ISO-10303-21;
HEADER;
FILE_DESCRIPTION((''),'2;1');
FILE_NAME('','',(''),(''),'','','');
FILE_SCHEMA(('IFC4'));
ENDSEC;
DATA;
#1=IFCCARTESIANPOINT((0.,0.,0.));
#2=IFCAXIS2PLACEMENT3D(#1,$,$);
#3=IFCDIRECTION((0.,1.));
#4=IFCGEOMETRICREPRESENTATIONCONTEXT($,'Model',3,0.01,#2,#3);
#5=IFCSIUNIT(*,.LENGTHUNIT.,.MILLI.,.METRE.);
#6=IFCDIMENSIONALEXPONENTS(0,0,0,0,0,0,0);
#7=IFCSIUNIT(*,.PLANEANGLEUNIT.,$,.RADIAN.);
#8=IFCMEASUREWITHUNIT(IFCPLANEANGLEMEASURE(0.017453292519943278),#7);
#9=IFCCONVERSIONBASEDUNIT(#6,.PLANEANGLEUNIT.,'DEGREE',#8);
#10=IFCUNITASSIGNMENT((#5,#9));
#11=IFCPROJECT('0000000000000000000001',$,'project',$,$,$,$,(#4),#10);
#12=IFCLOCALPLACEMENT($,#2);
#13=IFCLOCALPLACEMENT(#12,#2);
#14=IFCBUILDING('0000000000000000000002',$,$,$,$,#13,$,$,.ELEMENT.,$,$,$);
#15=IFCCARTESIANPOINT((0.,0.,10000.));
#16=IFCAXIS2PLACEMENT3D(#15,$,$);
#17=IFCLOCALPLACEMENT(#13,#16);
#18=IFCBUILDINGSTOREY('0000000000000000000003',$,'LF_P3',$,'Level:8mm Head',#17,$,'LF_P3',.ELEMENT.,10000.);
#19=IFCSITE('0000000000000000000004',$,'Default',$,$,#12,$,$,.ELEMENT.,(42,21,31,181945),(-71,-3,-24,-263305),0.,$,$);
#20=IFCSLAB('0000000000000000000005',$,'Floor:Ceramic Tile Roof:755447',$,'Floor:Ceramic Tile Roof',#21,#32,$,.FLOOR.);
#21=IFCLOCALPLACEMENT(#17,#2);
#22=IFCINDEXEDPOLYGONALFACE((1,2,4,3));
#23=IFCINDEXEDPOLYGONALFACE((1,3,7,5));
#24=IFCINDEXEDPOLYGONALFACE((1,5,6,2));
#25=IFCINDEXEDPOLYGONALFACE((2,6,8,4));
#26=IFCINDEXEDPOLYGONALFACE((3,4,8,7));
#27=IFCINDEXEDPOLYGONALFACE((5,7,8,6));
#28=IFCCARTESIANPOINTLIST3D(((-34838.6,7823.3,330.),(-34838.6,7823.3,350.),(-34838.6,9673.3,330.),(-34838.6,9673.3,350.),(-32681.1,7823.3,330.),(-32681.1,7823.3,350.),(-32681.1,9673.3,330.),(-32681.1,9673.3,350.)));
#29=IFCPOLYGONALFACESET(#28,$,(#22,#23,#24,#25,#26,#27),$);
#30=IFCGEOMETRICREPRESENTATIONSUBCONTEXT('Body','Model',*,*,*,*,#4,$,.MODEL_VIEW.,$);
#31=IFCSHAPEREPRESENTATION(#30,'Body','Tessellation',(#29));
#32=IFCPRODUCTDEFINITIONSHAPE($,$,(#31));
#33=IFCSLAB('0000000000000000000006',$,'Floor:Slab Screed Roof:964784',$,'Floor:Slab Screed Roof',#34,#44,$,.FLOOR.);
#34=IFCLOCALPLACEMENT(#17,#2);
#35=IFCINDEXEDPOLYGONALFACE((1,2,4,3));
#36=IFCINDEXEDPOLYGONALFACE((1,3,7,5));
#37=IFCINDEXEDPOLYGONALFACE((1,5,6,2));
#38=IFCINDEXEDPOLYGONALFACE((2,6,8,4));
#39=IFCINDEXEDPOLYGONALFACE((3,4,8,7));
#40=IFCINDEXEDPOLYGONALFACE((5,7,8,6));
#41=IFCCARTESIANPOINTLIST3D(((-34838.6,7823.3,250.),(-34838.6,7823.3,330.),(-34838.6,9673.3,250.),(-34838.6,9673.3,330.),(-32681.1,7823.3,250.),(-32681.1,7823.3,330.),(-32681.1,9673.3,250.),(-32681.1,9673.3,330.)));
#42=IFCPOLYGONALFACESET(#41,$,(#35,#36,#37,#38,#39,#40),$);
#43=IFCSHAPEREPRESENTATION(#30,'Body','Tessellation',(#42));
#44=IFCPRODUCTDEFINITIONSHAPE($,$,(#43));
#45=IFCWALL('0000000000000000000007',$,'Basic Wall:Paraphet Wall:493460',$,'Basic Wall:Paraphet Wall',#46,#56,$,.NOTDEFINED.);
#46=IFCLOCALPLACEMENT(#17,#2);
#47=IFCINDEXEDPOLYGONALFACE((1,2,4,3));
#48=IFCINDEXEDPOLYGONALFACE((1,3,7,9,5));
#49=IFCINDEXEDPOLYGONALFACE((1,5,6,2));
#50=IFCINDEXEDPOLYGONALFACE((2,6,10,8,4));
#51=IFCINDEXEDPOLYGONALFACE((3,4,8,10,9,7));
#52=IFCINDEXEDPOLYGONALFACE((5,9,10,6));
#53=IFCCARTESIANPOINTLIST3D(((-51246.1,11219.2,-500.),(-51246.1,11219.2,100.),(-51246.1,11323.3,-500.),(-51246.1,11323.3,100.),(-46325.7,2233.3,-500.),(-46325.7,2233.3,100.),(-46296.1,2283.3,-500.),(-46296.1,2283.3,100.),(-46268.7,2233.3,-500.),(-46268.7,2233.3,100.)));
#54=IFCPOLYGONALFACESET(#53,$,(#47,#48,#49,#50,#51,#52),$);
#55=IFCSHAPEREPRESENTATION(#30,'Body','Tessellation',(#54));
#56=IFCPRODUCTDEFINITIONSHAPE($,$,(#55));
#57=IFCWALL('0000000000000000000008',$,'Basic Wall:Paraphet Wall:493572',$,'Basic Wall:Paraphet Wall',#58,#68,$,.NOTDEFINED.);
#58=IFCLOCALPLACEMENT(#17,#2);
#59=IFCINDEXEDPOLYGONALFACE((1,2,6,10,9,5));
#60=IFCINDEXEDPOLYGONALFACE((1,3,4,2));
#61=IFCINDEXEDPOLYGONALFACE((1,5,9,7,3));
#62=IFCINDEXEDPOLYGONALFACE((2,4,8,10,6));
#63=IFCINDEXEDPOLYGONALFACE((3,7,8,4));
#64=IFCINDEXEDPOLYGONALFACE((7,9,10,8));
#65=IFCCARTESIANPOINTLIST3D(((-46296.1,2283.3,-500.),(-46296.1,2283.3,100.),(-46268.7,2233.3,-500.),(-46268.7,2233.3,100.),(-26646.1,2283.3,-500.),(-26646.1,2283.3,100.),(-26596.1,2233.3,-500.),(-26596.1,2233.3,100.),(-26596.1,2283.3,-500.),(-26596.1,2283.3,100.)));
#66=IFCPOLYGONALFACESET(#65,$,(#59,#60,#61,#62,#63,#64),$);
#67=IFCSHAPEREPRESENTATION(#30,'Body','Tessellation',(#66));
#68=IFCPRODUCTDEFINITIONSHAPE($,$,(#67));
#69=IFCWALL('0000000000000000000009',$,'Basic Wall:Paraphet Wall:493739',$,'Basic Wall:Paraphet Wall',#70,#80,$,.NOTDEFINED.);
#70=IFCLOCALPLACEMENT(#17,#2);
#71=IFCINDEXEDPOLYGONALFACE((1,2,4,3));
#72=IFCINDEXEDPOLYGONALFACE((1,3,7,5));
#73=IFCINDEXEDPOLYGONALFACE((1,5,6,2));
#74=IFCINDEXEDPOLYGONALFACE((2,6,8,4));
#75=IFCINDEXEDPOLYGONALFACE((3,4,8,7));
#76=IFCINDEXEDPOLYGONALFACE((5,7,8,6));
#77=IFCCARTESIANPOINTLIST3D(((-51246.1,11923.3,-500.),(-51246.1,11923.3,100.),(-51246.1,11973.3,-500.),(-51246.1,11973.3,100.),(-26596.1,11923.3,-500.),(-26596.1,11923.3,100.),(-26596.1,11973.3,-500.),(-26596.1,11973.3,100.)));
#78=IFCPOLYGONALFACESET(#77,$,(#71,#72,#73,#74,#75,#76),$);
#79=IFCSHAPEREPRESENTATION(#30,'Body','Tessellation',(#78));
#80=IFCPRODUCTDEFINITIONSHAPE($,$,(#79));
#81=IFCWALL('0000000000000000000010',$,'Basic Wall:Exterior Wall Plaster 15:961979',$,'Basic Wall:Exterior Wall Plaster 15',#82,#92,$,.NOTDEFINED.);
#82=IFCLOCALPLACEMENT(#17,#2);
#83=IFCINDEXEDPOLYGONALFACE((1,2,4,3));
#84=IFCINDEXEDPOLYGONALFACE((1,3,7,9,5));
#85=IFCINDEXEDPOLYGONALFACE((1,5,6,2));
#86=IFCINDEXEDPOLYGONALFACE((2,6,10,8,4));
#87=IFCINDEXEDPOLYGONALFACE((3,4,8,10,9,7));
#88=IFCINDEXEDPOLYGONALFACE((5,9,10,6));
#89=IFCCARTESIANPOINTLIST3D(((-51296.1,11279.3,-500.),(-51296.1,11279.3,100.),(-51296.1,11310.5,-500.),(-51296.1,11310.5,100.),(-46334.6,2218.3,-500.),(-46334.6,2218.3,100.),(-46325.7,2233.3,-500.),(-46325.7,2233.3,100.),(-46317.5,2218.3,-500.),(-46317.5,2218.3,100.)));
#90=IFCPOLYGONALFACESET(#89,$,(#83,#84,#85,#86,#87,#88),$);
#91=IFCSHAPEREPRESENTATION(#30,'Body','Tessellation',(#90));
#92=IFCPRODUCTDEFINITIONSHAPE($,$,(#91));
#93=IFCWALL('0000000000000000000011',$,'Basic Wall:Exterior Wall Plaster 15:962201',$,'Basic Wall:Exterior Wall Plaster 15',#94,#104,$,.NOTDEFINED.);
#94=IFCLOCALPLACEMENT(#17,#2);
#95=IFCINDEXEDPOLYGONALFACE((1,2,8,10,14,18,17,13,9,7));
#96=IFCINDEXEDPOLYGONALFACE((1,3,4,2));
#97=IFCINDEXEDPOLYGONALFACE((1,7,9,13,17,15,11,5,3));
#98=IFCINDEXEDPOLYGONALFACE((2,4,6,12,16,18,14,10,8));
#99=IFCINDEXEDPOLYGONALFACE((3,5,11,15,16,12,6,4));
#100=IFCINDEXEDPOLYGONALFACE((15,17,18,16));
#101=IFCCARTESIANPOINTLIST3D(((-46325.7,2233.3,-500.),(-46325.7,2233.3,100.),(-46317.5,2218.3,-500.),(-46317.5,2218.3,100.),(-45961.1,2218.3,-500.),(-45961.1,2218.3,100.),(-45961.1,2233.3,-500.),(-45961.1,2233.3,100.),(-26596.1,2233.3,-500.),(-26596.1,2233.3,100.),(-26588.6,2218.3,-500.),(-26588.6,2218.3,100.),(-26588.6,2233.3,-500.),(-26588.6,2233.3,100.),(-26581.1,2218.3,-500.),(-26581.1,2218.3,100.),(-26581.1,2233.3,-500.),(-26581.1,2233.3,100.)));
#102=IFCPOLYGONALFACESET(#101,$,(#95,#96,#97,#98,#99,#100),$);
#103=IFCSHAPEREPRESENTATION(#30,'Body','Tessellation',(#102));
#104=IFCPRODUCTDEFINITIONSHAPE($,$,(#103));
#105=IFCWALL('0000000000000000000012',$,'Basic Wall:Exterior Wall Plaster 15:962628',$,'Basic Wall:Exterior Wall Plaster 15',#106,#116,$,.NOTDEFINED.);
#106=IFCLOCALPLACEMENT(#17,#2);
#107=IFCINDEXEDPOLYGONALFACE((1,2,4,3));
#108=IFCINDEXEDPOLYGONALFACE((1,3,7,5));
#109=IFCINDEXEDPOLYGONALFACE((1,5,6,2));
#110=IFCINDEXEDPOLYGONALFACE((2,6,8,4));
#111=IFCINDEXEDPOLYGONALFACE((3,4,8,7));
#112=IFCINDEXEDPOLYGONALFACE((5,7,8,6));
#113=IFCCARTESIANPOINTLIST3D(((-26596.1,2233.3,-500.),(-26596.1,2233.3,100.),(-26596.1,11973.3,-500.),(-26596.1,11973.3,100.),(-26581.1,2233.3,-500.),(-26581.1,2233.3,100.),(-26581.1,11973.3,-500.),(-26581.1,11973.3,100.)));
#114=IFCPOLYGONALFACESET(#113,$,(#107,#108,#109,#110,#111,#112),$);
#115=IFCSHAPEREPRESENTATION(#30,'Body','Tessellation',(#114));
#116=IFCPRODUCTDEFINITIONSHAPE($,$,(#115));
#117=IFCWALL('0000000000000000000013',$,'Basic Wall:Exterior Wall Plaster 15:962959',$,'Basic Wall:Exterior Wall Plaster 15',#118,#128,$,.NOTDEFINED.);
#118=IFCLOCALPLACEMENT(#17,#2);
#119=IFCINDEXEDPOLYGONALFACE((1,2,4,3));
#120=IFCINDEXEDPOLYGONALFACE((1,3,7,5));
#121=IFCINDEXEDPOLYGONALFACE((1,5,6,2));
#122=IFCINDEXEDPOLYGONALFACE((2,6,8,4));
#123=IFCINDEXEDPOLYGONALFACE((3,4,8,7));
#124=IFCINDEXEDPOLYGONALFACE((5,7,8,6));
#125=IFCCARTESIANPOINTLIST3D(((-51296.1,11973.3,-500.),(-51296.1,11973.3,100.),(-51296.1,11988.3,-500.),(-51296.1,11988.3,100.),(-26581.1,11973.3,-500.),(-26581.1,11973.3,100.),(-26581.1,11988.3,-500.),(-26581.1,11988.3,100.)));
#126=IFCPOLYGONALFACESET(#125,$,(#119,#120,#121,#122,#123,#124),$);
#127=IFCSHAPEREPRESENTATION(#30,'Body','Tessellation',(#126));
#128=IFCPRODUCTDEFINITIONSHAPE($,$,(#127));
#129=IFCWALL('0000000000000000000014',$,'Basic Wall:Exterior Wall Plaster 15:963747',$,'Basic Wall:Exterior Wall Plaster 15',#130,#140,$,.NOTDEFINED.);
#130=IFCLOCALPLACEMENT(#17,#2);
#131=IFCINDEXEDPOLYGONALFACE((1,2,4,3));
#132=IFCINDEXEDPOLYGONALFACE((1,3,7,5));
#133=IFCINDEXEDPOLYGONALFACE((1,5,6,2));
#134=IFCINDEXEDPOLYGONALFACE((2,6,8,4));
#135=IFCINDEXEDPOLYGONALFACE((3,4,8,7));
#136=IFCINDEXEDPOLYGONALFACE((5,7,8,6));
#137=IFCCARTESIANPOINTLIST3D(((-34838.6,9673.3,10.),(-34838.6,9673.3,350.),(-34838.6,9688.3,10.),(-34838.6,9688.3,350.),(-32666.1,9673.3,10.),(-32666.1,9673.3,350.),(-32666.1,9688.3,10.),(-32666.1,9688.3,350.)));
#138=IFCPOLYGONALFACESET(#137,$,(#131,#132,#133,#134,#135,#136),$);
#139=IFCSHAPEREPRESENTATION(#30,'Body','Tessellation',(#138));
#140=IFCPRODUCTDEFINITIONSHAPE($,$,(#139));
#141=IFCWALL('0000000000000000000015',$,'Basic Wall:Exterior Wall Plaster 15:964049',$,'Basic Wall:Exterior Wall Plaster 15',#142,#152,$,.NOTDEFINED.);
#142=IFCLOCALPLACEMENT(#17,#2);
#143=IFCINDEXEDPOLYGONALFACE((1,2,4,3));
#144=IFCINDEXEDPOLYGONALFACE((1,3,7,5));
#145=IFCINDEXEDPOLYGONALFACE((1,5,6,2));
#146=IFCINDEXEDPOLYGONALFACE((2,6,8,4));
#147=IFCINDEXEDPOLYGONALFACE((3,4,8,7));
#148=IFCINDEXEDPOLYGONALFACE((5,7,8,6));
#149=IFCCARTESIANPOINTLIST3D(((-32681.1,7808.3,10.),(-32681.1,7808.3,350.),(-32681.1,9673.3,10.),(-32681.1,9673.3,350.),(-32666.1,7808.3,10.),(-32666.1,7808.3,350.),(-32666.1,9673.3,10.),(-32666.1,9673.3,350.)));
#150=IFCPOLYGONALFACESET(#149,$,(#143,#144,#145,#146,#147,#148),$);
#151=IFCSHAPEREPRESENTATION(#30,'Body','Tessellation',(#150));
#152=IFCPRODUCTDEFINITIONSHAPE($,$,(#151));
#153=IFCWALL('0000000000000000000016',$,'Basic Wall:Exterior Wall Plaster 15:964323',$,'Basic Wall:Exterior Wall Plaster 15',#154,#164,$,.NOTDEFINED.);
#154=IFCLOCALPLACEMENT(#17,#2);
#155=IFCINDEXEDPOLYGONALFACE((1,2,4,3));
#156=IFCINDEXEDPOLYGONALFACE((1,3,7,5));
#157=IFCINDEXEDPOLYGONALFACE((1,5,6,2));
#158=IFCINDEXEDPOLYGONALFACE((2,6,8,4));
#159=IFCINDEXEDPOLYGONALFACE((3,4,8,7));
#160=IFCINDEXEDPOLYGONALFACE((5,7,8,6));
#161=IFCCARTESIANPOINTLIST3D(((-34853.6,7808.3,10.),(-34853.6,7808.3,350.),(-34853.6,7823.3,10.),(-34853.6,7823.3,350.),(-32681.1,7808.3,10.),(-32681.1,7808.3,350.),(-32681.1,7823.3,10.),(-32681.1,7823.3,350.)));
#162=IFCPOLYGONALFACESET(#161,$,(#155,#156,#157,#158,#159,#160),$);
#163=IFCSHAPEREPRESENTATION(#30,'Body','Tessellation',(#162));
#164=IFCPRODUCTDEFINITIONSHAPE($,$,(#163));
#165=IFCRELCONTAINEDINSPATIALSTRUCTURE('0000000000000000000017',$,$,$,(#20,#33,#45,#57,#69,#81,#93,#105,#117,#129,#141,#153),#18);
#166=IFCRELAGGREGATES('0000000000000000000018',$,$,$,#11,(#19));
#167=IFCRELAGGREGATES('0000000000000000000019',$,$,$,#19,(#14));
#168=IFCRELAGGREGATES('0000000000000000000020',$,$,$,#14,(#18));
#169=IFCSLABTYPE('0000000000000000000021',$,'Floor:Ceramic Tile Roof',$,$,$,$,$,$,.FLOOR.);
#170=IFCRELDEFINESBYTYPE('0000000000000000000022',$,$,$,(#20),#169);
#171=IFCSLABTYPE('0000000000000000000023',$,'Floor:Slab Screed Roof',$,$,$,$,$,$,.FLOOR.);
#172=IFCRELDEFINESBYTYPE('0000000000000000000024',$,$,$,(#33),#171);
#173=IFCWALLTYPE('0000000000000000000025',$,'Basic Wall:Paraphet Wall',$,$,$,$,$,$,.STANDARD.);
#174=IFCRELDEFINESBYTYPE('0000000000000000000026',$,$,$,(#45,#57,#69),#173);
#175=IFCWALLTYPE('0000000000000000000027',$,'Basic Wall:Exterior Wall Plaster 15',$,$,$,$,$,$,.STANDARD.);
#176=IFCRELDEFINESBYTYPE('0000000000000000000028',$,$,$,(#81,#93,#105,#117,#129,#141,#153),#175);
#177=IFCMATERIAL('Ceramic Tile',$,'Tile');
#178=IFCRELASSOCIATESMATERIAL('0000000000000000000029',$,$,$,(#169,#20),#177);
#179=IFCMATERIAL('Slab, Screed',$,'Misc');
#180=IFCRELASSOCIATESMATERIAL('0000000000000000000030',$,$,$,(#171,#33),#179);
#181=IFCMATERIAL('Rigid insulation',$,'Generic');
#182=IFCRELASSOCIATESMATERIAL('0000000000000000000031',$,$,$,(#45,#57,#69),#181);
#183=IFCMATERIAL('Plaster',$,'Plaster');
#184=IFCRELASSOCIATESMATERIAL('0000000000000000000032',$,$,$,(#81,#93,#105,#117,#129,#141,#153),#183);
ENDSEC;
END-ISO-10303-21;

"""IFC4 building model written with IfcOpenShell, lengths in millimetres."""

from ifc_helpers import new_model, entity, si_unit, converted_unit, direction, frame, origin, place, context, subcontext, project, spatial, indexed_curve, outline, extrude, material, type_object, element, save


model = new_model("IFC4")

# Units and contexts
model_context = context("Model", 3, precision=0.01, world=origin(), true_north=direction((0.0, 1.0)))
body_context = subcontext(model_context, "Body", "Model", "MODEL_VIEW")
ifc_project = project(units=[si_unit("LENGTHUNIT", "METRE", prefix="MILLI"), converted_unit("PLANEANGLEUNIT", "DEGREE", entity("IfcPlaneAngleMeasure", 0.017453292519943278), si_unit("PLANEANGLEUNIT", "RADIAN"), dimensions=[0, 0, 0, 0, 0, 0, 0])], contexts=[model_context])

# Site, building, storey
site_placement = place(None, origin())
site = spatial("IfcSite", under=ifc_project, at=site_placement, Name="Default", CompositionType="ELEMENT", RefLatitude=(42, 21, 31, 181945), RefLongitude=(-71, -3, -24, -263305), RefElevation=0.0)
building_placement = place(site_placement, origin())
building = spatial("IfcBuilding", under=site, at=building_placement, CompositionType="ELEMENT")
storey_placement = place(building_placement, frame((0.0, 0.0, 10000.0)))
storey = spatial("IfcBuildingStorey", under=building, at=storey_placement, Name="LF_P3", ObjectType="Level:8mm Head", LongName="LF_P3", CompositionType="ELEMENT", Elevation=10000.0)

# Slab
ifc_material_1 = material(Name="Ceramic Tile", Category="Tile")
slab_type_1 = type_object("IfcSlabType", Name="Floor:Ceramic Tile Roof", PredefinedType="FLOOR", material=ifc_material_1)
slab_1_placement = place(storey_placement, origin())
element("IfcSlab", 1, at=slab_1_placement, inside=storey, type_object=slab_type_1, material=ifc_material_1, Name="Floor:Ceramic Tile Roof:755447", ObjectType="Floor:Ceramic Tile Roof", PredefinedType="FLOOR", context=body_context, shape_type="SweptSolid", body=[
    extrude(outline(indexed_curve([(-925.0, -1078.8), (925.0, -1078.8), (925.0, 1078.8), (-925.0, 1078.8), (-925.0, -1078.8)], self_intersect=False)), frame((-33759.9, 8748.3, 350.0), z_axis=(0.0, 0.0, -1.0), x_axis=(0.0, 1.0, 0.0)), (0.0, 0.0, 1.0), 20.0),
])

# Shared definitions
ifc_material_2 = material(Name="Rigid insulation", Category="Generic")
ifc_material_3 = material(Name="Slab, Screed", Category="Misc")
slab_type_2 = type_object("IfcSlabType", Name="Floor:Slab Screed Roof", PredefinedType="FLOOR", material=ifc_material_3)

# Slab
slab_2_placement = place(storey_placement, origin())
element("IfcSlab", 2, at=slab_2_placement, inside=storey, type_object=slab_type_2, material=ifc_material_3, Name="Floor:Slab Screed Roof:964784", ObjectType="Floor:Slab Screed Roof", PredefinedType="FLOOR", context=body_context, shape_type="SweptSolid", body=[
    extrude(outline(indexed_curve([(-925.0, -1078.8), (925.0, -1078.8), (925.0, 1078.8), (-925.0, 1078.8), (-925.0, -1078.8)], self_intersect=False)), frame((-33759.9, 8748.3, 330.0), z_axis=(0.0, 0.0, -1.0), x_axis=(0.0, 1.0, 0.0)), (0.0, 0.0, 1.0), 80.0),
])

# Walls
wall_type_1 = type_object("IfcWallType", Name="Basic Wall:Paraphet Wall", PredefinedType="STANDARD")
wall_1_placement = place(storey_placement, frame((-51268.0, 11311.3, -500.0), z_axis=(0.0, 0.0, 1.0), x_axis=(0.480279, -0.877116, 0.0)))
element("IfcWall", 3, at=wall_1_placement, inside=storey, type_object=wall_type_1, material=ifc_material_2, Name="Basic Wall:Paraphet Wall:493460", ObjectType="Basic Wall:Paraphet Wall", PredefinedType="NOTDEFINED", context=body_context, shape_type="SweptSolid", body=[
    extrude(outline(indexed_curve([(10336.1, -25.0), (10363.5, 25.0), (10306.5, 25.0), (0.0, 25.0), (91.3, -25.0), (10336.1, -25.0)], self_intersect=False)), origin(), (0.0, 0.0, 1.0), 600.0),
])
wall_2_placement = place(storey_placement, frame((-46296.1, 2258.3, -500.0)))
element("IfcWall", 4, at=wall_2_placement, inside=storey, type_object=wall_type_1, material=ifc_material_2, Name="Basic Wall:Paraphet Wall:493572", ObjectType="Basic Wall:Paraphet Wall", PredefinedType="NOTDEFINED", context=body_context, shape_type="SweptSolid", body=[
    extrude(outline(indexed_curve([(19700.0, -25.0), (19700.0, 25.0), (19650.0, 25.0), (0.0, 25.0), (27.4, -25.0), (19700.0, -25.0)], self_intersect=False)), origin(), (0.0, 0.0, 1.0), 600.0),
])
wall_3_placement = place(storey_placement, frame((-26596.1, 11948.3, -500.0), z_axis=(0.0, 0.0, 1.0), x_axis=(-1.0, 0.0, 0.0)))
element("IfcWall", 5, at=wall_3_placement, inside=storey, type_object=wall_type_1, material=ifc_material_2, Name="Basic Wall:Paraphet Wall:493739", ObjectType="Basic Wall:Paraphet Wall", PredefinedType="NOTDEFINED", context=body_context, shape_type="SweptSolid", body=[
    extrude(outline(indexed_curve([(24650.0, 25.0), (0.0, 25.0), (0.0, -25.0), (24650.0, -25.0), (24650.0, 25.0)], self_intersect=False)), origin(), (0.0, 0.0, 1.0), 600.0),
])
ifc_material_4 = material(Name="Plaster", Category="Plaster")
wall_type_2 = type_object("IfcWallType", Name="Basic Wall:Exterior Wall Plaster 15", PredefinedType="STANDARD")
wall_4_placement = place(storey_placement, frame((-51302.7, 11306.9, -500.0), z_axis=(0.0, 0.0, 1.0), x_axis=(0.480279, -0.877116, 0.0)))
element("IfcWall", 6, at=wall_4_placement, inside=storey, type_object=wall_type_2, material=ifc_material_4, Name="Basic Wall:Exterior Wall Plaster 15:961979", ObjectType="Basic Wall:Exterior Wall Plaster 15", PredefinedType="NOTDEFINED", context=body_context, shape_type="SweptSolid", body=[
    extrude(outline(indexed_curve([(10357.8, -7.5), (10366.0, 7.5), (10348.9, 7.5), (0.0, 7.5), (27.4, -7.5), (10357.8, -7.5)], self_intersect=False)), origin(), (0.0, 0.0, 1.0), 600.0),
])
wall_5_placement = place(storey_placement, frame((-46325.7, 2225.8, -500.0)))
element("IfcWall", 7, at=wall_5_placement, inside=storey, type_object=wall_type_2, material=ifc_material_4, Name="Basic Wall:Exterior Wall Plaster 15:962201", ObjectType="Basic Wall:Exterior Wall Plaster 15", PredefinedType="NOTDEFINED", context=body_context, shape_type="SweptSolid", body=[
    extrude(outline(indexed_curve([(19744.6, -7.5), (19744.6, 7.5), (19737.1, 7.5), (19729.6, 7.5), (364.6, 7.5), (0.0, 7.5), (8.2, -7.5), (364.6, -7.5), (19737.1, -7.5), (19744.6, -7.5)], self_intersect=False)), origin(), (0.0, 0.0, 1.0), 600.0),
])
wall_6_placement = place(storey_placement, frame((-26588.6, 2233.3, -500.0), z_axis=(0.0, 0.0, 1.0), x_axis=(0.0, 1.0, 0.0)))
element("IfcWall", 8, at=wall_6_placement, inside=storey, type_object=wall_type_2, material=ifc_material_4, Name="Basic Wall:Exterior Wall Plaster 15:962628", ObjectType="Basic Wall:Exterior Wall Plaster 15", PredefinedType="NOTDEFINED", context=body_context, shape_type="SweptSolid", body=[
    extrude(outline(indexed_curve([(9740.0, 7.5), (0.0, 7.5), (0.0, -7.5), (9740.0, -7.5), (9740.0, 7.5)], self_intersect=False)), origin(), (0.0, 0.0, 1.0), 600.0),
])
wall_7_placement = place(storey_placement, frame((-26581.1, 11980.8, -500.0), z_axis=(0.0, 0.0, 1.0), x_axis=(-1.0, 0.0, 0.0)))
element("IfcWall", 9, at=wall_7_placement, inside=storey, type_object=wall_type_2, material=ifc_material_4, Name="Basic Wall:Exterior Wall Plaster 15:962959", ObjectType="Basic Wall:Exterior Wall Plaster 15", PredefinedType="NOTDEFINED", context=body_context, shape_type="SweptSolid", body=[
    extrude(outline(indexed_curve([(24715.0, 7.5), (0.0, 7.5), (0.0, -7.5), (24715.0, -7.5), (24715.0, 7.5)], self_intersect=False)), origin(), (0.0, 0.0, 1.0), 600.0),
])
wall_8_placement = place(storey_placement, frame((-32666.1, 9680.8, 10.0), z_axis=(0.0, 0.0, 1.0), x_axis=(-1.0, 0.0, 0.0)))
element("IfcWall", 10, at=wall_8_placement, inside=storey, type_object=wall_type_2, material=ifc_material_4, Name="Basic Wall:Exterior Wall Plaster 15:963747", ObjectType="Basic Wall:Exterior Wall Plaster 15", PredefinedType="NOTDEFINED", context=body_context, shape_type="SweptSolid", body=[
    extrude(outline(indexed_curve([(2172.5, 7.5), (0.0, 7.5), (0.0, -7.5), (2172.5, -7.5), (2172.5, 7.5)], self_intersect=False)), origin(), (0.0, 0.0, 1.0), 340.0),
])
wall_9_placement = place(storey_placement, frame((-32673.6, 9673.3, 10.0), z_axis=(0.0, 0.0, 1.0), x_axis=(0.0, -1.0, 0.0)))
element("IfcWall", 11, at=wall_9_placement, inside=storey, type_object=wall_type_2, material=ifc_material_4, Name="Basic Wall:Exterior Wall Plaster 15:964049", ObjectType="Basic Wall:Exterior Wall Plaster 15", PredefinedType="NOTDEFINED", context=body_context, shape_type="SweptSolid", body=[
    extrude(outline(indexed_curve([(1865.0, 7.5), (0.0, 7.5), (0.0, -7.5), (1865.0, -7.5), (1865.0, 7.5)], self_intersect=False)), origin(), (0.0, 0.0, 1.0), 340.0),
])
wall_10_placement = place(storey_placement, frame((-32681.1, 7815.8, 10.0), z_axis=(0.0, 0.0, 1.0), x_axis=(-1.0, 0.0, 0.0)))
element("IfcWall", 12, at=wall_10_placement, inside=storey, type_object=wall_type_2, material=ifc_material_4, Name="Basic Wall:Exterior Wall Plaster 15:964323", ObjectType="Basic Wall:Exterior Wall Plaster 15", PredefinedType="NOTDEFINED", context=body_context, shape_type="SweptSolid", body=[
    extrude(outline(indexed_curve([(2172.5, 7.5), (0.0, 7.5), (0.0, -7.5), (2172.5, -7.5), (2172.5, 7.5)], self_intersect=False)), origin(), (0.0, 0.0, 1.0), 340.0),
])

save(model, "model.ifc")
